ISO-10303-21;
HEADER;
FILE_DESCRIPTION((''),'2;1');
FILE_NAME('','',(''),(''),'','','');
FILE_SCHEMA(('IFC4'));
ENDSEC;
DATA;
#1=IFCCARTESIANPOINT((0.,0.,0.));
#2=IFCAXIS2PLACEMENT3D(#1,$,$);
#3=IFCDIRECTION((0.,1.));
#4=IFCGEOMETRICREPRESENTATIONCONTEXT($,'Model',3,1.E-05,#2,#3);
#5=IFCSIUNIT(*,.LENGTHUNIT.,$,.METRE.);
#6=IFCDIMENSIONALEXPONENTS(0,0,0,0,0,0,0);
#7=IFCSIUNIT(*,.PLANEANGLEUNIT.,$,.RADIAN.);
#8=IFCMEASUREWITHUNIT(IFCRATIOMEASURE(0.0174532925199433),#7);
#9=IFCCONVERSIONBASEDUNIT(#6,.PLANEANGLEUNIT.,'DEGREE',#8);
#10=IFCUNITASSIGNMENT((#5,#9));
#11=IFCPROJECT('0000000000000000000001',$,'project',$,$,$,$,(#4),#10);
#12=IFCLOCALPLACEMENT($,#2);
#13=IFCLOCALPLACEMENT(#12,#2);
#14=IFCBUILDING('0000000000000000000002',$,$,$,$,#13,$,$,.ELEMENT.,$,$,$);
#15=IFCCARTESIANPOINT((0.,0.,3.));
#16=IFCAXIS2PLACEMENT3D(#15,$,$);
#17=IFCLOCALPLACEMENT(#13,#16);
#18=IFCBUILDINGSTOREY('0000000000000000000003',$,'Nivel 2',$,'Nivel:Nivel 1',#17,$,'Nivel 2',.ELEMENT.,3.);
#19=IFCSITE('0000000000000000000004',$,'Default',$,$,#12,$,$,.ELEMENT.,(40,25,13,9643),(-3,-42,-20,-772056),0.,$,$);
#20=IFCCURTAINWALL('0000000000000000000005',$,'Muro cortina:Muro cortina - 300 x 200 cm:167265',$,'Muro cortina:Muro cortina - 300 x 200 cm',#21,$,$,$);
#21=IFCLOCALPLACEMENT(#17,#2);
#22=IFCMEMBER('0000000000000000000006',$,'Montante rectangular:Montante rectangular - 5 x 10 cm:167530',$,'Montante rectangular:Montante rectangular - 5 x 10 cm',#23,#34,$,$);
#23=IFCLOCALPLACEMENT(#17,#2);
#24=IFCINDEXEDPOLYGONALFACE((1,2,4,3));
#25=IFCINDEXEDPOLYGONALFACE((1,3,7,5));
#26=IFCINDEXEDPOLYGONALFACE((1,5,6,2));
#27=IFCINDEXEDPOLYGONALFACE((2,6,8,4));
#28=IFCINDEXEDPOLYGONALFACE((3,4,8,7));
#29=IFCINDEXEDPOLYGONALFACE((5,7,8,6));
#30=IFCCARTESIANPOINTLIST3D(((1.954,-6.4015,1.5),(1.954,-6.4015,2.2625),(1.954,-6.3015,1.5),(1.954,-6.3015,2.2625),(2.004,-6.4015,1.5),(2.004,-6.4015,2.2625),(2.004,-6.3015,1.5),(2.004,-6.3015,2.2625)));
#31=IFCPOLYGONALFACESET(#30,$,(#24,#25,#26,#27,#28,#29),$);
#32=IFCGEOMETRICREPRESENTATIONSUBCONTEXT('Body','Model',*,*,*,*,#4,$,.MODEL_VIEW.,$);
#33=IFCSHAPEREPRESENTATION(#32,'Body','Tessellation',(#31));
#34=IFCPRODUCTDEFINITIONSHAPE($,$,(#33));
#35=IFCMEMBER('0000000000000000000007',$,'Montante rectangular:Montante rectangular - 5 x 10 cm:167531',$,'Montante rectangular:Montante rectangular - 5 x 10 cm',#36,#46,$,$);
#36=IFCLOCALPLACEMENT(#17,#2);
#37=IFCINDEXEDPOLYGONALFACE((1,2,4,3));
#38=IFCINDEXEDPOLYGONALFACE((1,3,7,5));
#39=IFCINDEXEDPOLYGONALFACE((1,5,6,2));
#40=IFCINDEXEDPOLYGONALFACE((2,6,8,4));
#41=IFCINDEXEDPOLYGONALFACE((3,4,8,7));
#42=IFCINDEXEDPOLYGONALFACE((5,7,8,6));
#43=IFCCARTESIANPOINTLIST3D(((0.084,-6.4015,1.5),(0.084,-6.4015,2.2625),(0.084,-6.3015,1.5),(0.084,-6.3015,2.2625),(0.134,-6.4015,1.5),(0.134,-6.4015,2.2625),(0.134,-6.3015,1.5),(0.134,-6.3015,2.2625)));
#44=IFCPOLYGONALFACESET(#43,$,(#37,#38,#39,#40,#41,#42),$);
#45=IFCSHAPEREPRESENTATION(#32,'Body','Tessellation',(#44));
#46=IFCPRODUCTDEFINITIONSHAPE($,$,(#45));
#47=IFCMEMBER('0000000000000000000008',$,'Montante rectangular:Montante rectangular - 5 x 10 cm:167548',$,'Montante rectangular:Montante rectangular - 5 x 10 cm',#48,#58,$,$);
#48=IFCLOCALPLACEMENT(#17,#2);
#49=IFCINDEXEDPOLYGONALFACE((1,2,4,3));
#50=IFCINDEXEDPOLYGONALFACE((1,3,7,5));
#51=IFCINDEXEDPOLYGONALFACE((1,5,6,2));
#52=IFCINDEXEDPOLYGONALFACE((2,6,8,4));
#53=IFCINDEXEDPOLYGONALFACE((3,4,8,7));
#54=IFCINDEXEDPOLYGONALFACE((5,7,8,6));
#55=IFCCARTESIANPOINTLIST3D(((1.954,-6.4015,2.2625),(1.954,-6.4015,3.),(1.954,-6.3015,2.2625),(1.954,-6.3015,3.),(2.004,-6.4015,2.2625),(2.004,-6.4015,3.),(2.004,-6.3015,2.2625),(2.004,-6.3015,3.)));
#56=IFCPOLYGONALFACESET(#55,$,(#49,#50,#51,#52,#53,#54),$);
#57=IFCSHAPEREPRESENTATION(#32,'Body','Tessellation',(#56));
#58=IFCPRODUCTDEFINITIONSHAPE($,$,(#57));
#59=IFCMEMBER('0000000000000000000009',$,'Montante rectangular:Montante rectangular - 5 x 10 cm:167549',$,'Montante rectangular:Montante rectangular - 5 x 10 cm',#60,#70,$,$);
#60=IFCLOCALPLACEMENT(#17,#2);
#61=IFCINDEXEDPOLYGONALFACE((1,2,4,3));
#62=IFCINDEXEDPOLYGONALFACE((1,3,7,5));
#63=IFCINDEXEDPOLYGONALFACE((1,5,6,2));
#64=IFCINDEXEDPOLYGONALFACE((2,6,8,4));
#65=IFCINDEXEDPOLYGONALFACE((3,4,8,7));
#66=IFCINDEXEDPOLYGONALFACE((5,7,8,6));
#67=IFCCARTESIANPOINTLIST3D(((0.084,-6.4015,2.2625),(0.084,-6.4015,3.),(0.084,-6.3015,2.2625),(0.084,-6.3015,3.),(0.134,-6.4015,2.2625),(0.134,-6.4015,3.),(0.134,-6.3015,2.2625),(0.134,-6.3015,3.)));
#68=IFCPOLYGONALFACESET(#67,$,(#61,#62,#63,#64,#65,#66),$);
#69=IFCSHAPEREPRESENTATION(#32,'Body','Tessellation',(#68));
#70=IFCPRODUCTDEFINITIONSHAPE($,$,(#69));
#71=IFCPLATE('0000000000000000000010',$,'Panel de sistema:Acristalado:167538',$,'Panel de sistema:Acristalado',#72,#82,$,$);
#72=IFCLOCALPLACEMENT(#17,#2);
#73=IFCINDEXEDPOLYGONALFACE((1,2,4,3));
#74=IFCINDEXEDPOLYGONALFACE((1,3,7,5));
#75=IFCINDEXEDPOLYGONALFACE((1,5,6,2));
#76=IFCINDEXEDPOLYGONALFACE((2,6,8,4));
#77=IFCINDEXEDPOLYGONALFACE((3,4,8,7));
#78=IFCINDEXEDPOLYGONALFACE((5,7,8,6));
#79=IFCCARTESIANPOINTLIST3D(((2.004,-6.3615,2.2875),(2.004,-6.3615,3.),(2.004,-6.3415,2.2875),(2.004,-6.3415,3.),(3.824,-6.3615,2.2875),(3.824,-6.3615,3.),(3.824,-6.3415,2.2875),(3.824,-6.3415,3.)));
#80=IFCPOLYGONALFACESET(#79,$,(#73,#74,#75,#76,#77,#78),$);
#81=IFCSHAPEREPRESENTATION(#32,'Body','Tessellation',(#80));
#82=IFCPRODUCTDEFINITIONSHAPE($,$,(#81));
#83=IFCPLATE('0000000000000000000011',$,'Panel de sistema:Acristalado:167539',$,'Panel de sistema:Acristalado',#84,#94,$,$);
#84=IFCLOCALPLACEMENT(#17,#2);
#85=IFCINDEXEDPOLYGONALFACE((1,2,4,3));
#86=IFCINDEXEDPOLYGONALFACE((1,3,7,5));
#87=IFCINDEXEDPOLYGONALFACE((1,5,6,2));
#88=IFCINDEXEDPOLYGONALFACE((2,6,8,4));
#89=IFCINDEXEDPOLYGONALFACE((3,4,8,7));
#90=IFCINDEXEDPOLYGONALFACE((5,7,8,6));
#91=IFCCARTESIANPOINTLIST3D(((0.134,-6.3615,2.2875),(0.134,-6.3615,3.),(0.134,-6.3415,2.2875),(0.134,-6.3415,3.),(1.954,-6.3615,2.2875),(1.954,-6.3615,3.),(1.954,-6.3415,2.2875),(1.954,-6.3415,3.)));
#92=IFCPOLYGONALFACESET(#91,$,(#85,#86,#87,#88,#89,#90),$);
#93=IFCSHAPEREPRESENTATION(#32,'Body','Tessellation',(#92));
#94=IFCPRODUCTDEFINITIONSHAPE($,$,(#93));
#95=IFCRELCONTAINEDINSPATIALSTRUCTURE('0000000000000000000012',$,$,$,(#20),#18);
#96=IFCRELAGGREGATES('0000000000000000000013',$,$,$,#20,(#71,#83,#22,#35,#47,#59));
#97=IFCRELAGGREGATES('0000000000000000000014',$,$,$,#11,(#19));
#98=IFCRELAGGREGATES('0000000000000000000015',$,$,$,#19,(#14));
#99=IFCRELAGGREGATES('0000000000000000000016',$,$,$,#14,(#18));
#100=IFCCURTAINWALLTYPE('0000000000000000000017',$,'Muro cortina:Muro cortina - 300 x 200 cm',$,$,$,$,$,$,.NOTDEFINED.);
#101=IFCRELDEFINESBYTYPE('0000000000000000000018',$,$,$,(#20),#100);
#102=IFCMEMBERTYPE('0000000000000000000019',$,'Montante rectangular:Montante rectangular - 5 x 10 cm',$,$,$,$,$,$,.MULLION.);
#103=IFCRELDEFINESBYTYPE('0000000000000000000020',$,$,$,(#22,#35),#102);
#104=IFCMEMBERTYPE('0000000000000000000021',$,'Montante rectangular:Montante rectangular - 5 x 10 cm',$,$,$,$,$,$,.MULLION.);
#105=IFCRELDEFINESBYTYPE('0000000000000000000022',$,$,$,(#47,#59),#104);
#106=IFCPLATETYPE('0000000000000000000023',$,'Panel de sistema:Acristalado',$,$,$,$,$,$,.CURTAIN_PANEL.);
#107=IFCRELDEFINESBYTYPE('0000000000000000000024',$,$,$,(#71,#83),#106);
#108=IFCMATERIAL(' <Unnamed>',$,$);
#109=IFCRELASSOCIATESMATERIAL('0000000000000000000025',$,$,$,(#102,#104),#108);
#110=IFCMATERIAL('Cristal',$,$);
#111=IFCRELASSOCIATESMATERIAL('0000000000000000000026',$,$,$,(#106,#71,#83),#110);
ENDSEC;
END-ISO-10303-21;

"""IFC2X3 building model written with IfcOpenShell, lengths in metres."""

from ifc_helpers import new_model, entity, si_unit, converted_unit, direction, frame, origin, origin_2d_with_axis, place, context, subcontext, project, spatial, rectangle, extrude, source, transform, mapped, material, type_object, type_shapes, element, aggregate, save


model = new_model("IFC2X3")

# Units and contexts
model_context = context("Model", 3, precision=1e-05, world=origin(), true_north=direction((0.0, 1.0)))
body_context = subcontext(model_context, "Body", "Model", "MODEL_VIEW")
ifc_project = project(units=[si_unit("LENGTHUNIT", "METRE"), converted_unit("PLANEANGLEUNIT", "DEGREE", entity("IfcRatioMeasure", 0.0174532925199433), si_unit("PLANEANGLEUNIT", "RADIAN"), dimensions=[0, 0, 0, 0, 0, 0, 0])], contexts=[model_context])

# Site, building, storey
site_placement = place(None, origin())
site = spatial("IfcSite", under=ifc_project, at=site_placement, Name="Default", CompositionType="ELEMENT", RefLatitude=(40, 25, 13, 9643), RefLongitude=(-3, -42, -20, -772056), RefElevation=0.0)
building_placement = place(site_placement, origin())
building = spatial("IfcBuilding", under=site, at=building_placement, CompositionType="ELEMENT")
storey_placement = place(building_placement, frame((0.0, 0.0, 3.0)))
storey = spatial("IfcBuildingStorey", under=building, at=storey_placement, Name="Nivel 2", ObjectType="Nivel:Nivel 1", LongName="Nivel 2", CompositionType="ELEMENT", Elevation=3.0)

# Curtain wall, members, plates
curtain_wall_type = type_object("IfcCurtainWallType", Name="Muro cortina:Muro cortina - 300 x 200 cm", PredefinedType="NOTDEFINED")
curtain_wall_placement = place(storey_placement, frame((0.0, 0.0, -3.0)))
curtain_wall = element("IfcCurtainWall", 1, at=curtain_wall_placement, inside=storey, type_object=curtain_wall_type, Name="Muro cortina:Muro cortina - 300 x 200 cm:167265", ObjectType="Muro cortina:Muro cortina - 300 x 200 cm")
ifc_material_1 = material(Name=" <Unnamed>")
member_type_1 = type_object("IfcMemberType", Name="Montante rectangular:Montante rectangular - 5 x 10 cm", PredefinedType="MULLION", material=ifc_material_1)
shared_shape_1 = source(origin(), body_context, "Body", "SweptSolid", [
    extrude(rectangle(XDim=0.1, YDim=0.05, at=origin_2d_with_axis()), frame((0.0, 0.0, -0.7625), z_axis=(0.0, 0.0, 1.0), x_axis=(0.0, -1.0, 0.0)), (0.0, 0.0, 1.0), 0.7625),
])
type_shapes(member_type_1, [shared_shape_1])
member_1_placement = place(storey_placement, frame((1.979, -6.3515, 1.5), z_axis=(0.0, 0.0, -1.0), x_axis=(-1.0, 0.0, 0.0)))
member_1 = element("IfcMember", 2, at=member_1_placement, type_object=member_type_1, Name="Montante rectangular:Montante rectangular - 5 x 10 cm:167530", ObjectType="Montante rectangular:Montante rectangular - 5 x 10 cm", context=body_context, shape_type="MappedRepresentation", body=[
    mapped(shared_shape_1, transform((0.0, 0.0, 0.0), scale=1.0)),
])
member_2_placement = place(storey_placement, frame((0.109, -6.3515, 1.5), z_axis=(0.0, 0.0, -1.0), x_axis=(-1.0, 0.0, 0.0)))
member_2 = element("IfcMember", 3, at=member_2_placement, type_object=member_type_1, Name="Montante rectangular:Montante rectangular - 5 x 10 cm:167531", ObjectType="Montante rectangular:Montante rectangular - 5 x 10 cm", context=body_context, shape_type="MappedRepresentation", body=[
    mapped(shared_shape_1, transform((0.0, 0.0, 0.0), scale=1.0)),
])
member_type_2 = type_object("IfcMemberType", Name="Montante rectangular:Montante rectangular - 5 x 10 cm", PredefinedType="MULLION", material=ifc_material_1)
shared_shape_2 = source(origin(), body_context, "Body", "SweptSolid", [
    extrude(rectangle(XDim=0.1, YDim=0.05, at=origin_2d_with_axis()), frame((0.0, 0.0, -0.7375), z_axis=(0.0, 0.0, 1.0), x_axis=(0.0, -1.0, 0.0)), (0.0, 0.0, 1.0), 0.7375),
])
type_shapes(member_type_2, [shared_shape_2])
member_3_placement = place(storey_placement, frame((1.979, -6.3515, 2.2625), z_axis=(0.0, 0.0, -1.0), x_axis=(-1.0, 0.0, 0.0)))
member_3 = element("IfcMember", 4, at=member_3_placement, type_object=member_type_2, Name="Montante rectangular:Montante rectangular - 5 x 10 cm:167548", ObjectType="Montante rectangular:Montante rectangular - 5 x 10 cm", context=body_context, shape_type="MappedRepresentation", body=[
    mapped(shared_shape_2, transform((0.0, 0.0, 0.0), scale=1.0)),
])
member_4_placement = place(storey_placement, frame((0.109, -6.3515, 2.2625), z_axis=(0.0, 0.0, -1.0), x_axis=(-1.0, 0.0, 0.0)))
member_4 = element("IfcMember", 5, at=member_4_placement, type_object=member_type_2, Name="Montante rectangular:Montante rectangular - 5 x 10 cm:167549", ObjectType="Montante rectangular:Montante rectangular - 5 x 10 cm", context=body_context, shape_type="MappedRepresentation", body=[
    mapped(shared_shape_2, transform((0.0, 0.0, 0.0), scale=1.0)),
])
ifc_material_2 = material(Name="Cristal")
plate_type = type_object("IfcPlateType", Name="Panel de sistema:Acristalado", PredefinedType="CURTAIN_PANEL", material=ifc_material_2)
shared_shape_3 = source(origin(), body_context, "Body", "SweptSolid", [
    extrude(rectangle(XDim=0.02, YDim=1.82, at=origin_2d_with_axis()), frame((0.0, 0.0, 0.0), z_axis=(0.0, 0.0, 1.0), x_axis=(0.0, 1.0, 0.0)), (0.0, 0.0, 1.0), 0.7125),
])
type_shapes(plate_type, [shared_shape_3])
plate_1_placement = place(curtain_wall_placement, frame((2.914, -6.3515, 5.2875), z_axis=(0.0, 0.0, 1.0), x_axis=(-1.0, 0.0, 0.0)))
plate_1 = element("IfcPlate", 6, at=plate_1_placement, type_object=plate_type, material=ifc_material_2, Name="Panel de sistema:Acristalado:167538", ObjectType="Panel de sistema:Acristalado", context=body_context, shape_type="MappedRepresentation", body=[
    mapped(shared_shape_3, transform((0.0, 0.0, 0.0), scale=1.0)),
])
plate_2_placement = place(curtain_wall_placement, frame((1.044, -6.3515, 5.2875), z_axis=(0.0, 0.0, 1.0), x_axis=(-1.0, 0.0, 0.0)))
plate_2 = element("IfcPlate", 7, at=plate_2_placement, type_object=plate_type, material=ifc_material_2, Name="Panel de sistema:Acristalado:167539", ObjectType="Panel de sistema:Acristalado", context=body_context, shape_type="MappedRepresentation", body=[
    mapped(shared_shape_3, transform((0.0, 0.0, 0.0), scale=1.0)),
])
aggregate(curtain_wall, [plate_1, plate_2, member_1, member_2, member_3, member_4])

save(model, "model.ifc")
